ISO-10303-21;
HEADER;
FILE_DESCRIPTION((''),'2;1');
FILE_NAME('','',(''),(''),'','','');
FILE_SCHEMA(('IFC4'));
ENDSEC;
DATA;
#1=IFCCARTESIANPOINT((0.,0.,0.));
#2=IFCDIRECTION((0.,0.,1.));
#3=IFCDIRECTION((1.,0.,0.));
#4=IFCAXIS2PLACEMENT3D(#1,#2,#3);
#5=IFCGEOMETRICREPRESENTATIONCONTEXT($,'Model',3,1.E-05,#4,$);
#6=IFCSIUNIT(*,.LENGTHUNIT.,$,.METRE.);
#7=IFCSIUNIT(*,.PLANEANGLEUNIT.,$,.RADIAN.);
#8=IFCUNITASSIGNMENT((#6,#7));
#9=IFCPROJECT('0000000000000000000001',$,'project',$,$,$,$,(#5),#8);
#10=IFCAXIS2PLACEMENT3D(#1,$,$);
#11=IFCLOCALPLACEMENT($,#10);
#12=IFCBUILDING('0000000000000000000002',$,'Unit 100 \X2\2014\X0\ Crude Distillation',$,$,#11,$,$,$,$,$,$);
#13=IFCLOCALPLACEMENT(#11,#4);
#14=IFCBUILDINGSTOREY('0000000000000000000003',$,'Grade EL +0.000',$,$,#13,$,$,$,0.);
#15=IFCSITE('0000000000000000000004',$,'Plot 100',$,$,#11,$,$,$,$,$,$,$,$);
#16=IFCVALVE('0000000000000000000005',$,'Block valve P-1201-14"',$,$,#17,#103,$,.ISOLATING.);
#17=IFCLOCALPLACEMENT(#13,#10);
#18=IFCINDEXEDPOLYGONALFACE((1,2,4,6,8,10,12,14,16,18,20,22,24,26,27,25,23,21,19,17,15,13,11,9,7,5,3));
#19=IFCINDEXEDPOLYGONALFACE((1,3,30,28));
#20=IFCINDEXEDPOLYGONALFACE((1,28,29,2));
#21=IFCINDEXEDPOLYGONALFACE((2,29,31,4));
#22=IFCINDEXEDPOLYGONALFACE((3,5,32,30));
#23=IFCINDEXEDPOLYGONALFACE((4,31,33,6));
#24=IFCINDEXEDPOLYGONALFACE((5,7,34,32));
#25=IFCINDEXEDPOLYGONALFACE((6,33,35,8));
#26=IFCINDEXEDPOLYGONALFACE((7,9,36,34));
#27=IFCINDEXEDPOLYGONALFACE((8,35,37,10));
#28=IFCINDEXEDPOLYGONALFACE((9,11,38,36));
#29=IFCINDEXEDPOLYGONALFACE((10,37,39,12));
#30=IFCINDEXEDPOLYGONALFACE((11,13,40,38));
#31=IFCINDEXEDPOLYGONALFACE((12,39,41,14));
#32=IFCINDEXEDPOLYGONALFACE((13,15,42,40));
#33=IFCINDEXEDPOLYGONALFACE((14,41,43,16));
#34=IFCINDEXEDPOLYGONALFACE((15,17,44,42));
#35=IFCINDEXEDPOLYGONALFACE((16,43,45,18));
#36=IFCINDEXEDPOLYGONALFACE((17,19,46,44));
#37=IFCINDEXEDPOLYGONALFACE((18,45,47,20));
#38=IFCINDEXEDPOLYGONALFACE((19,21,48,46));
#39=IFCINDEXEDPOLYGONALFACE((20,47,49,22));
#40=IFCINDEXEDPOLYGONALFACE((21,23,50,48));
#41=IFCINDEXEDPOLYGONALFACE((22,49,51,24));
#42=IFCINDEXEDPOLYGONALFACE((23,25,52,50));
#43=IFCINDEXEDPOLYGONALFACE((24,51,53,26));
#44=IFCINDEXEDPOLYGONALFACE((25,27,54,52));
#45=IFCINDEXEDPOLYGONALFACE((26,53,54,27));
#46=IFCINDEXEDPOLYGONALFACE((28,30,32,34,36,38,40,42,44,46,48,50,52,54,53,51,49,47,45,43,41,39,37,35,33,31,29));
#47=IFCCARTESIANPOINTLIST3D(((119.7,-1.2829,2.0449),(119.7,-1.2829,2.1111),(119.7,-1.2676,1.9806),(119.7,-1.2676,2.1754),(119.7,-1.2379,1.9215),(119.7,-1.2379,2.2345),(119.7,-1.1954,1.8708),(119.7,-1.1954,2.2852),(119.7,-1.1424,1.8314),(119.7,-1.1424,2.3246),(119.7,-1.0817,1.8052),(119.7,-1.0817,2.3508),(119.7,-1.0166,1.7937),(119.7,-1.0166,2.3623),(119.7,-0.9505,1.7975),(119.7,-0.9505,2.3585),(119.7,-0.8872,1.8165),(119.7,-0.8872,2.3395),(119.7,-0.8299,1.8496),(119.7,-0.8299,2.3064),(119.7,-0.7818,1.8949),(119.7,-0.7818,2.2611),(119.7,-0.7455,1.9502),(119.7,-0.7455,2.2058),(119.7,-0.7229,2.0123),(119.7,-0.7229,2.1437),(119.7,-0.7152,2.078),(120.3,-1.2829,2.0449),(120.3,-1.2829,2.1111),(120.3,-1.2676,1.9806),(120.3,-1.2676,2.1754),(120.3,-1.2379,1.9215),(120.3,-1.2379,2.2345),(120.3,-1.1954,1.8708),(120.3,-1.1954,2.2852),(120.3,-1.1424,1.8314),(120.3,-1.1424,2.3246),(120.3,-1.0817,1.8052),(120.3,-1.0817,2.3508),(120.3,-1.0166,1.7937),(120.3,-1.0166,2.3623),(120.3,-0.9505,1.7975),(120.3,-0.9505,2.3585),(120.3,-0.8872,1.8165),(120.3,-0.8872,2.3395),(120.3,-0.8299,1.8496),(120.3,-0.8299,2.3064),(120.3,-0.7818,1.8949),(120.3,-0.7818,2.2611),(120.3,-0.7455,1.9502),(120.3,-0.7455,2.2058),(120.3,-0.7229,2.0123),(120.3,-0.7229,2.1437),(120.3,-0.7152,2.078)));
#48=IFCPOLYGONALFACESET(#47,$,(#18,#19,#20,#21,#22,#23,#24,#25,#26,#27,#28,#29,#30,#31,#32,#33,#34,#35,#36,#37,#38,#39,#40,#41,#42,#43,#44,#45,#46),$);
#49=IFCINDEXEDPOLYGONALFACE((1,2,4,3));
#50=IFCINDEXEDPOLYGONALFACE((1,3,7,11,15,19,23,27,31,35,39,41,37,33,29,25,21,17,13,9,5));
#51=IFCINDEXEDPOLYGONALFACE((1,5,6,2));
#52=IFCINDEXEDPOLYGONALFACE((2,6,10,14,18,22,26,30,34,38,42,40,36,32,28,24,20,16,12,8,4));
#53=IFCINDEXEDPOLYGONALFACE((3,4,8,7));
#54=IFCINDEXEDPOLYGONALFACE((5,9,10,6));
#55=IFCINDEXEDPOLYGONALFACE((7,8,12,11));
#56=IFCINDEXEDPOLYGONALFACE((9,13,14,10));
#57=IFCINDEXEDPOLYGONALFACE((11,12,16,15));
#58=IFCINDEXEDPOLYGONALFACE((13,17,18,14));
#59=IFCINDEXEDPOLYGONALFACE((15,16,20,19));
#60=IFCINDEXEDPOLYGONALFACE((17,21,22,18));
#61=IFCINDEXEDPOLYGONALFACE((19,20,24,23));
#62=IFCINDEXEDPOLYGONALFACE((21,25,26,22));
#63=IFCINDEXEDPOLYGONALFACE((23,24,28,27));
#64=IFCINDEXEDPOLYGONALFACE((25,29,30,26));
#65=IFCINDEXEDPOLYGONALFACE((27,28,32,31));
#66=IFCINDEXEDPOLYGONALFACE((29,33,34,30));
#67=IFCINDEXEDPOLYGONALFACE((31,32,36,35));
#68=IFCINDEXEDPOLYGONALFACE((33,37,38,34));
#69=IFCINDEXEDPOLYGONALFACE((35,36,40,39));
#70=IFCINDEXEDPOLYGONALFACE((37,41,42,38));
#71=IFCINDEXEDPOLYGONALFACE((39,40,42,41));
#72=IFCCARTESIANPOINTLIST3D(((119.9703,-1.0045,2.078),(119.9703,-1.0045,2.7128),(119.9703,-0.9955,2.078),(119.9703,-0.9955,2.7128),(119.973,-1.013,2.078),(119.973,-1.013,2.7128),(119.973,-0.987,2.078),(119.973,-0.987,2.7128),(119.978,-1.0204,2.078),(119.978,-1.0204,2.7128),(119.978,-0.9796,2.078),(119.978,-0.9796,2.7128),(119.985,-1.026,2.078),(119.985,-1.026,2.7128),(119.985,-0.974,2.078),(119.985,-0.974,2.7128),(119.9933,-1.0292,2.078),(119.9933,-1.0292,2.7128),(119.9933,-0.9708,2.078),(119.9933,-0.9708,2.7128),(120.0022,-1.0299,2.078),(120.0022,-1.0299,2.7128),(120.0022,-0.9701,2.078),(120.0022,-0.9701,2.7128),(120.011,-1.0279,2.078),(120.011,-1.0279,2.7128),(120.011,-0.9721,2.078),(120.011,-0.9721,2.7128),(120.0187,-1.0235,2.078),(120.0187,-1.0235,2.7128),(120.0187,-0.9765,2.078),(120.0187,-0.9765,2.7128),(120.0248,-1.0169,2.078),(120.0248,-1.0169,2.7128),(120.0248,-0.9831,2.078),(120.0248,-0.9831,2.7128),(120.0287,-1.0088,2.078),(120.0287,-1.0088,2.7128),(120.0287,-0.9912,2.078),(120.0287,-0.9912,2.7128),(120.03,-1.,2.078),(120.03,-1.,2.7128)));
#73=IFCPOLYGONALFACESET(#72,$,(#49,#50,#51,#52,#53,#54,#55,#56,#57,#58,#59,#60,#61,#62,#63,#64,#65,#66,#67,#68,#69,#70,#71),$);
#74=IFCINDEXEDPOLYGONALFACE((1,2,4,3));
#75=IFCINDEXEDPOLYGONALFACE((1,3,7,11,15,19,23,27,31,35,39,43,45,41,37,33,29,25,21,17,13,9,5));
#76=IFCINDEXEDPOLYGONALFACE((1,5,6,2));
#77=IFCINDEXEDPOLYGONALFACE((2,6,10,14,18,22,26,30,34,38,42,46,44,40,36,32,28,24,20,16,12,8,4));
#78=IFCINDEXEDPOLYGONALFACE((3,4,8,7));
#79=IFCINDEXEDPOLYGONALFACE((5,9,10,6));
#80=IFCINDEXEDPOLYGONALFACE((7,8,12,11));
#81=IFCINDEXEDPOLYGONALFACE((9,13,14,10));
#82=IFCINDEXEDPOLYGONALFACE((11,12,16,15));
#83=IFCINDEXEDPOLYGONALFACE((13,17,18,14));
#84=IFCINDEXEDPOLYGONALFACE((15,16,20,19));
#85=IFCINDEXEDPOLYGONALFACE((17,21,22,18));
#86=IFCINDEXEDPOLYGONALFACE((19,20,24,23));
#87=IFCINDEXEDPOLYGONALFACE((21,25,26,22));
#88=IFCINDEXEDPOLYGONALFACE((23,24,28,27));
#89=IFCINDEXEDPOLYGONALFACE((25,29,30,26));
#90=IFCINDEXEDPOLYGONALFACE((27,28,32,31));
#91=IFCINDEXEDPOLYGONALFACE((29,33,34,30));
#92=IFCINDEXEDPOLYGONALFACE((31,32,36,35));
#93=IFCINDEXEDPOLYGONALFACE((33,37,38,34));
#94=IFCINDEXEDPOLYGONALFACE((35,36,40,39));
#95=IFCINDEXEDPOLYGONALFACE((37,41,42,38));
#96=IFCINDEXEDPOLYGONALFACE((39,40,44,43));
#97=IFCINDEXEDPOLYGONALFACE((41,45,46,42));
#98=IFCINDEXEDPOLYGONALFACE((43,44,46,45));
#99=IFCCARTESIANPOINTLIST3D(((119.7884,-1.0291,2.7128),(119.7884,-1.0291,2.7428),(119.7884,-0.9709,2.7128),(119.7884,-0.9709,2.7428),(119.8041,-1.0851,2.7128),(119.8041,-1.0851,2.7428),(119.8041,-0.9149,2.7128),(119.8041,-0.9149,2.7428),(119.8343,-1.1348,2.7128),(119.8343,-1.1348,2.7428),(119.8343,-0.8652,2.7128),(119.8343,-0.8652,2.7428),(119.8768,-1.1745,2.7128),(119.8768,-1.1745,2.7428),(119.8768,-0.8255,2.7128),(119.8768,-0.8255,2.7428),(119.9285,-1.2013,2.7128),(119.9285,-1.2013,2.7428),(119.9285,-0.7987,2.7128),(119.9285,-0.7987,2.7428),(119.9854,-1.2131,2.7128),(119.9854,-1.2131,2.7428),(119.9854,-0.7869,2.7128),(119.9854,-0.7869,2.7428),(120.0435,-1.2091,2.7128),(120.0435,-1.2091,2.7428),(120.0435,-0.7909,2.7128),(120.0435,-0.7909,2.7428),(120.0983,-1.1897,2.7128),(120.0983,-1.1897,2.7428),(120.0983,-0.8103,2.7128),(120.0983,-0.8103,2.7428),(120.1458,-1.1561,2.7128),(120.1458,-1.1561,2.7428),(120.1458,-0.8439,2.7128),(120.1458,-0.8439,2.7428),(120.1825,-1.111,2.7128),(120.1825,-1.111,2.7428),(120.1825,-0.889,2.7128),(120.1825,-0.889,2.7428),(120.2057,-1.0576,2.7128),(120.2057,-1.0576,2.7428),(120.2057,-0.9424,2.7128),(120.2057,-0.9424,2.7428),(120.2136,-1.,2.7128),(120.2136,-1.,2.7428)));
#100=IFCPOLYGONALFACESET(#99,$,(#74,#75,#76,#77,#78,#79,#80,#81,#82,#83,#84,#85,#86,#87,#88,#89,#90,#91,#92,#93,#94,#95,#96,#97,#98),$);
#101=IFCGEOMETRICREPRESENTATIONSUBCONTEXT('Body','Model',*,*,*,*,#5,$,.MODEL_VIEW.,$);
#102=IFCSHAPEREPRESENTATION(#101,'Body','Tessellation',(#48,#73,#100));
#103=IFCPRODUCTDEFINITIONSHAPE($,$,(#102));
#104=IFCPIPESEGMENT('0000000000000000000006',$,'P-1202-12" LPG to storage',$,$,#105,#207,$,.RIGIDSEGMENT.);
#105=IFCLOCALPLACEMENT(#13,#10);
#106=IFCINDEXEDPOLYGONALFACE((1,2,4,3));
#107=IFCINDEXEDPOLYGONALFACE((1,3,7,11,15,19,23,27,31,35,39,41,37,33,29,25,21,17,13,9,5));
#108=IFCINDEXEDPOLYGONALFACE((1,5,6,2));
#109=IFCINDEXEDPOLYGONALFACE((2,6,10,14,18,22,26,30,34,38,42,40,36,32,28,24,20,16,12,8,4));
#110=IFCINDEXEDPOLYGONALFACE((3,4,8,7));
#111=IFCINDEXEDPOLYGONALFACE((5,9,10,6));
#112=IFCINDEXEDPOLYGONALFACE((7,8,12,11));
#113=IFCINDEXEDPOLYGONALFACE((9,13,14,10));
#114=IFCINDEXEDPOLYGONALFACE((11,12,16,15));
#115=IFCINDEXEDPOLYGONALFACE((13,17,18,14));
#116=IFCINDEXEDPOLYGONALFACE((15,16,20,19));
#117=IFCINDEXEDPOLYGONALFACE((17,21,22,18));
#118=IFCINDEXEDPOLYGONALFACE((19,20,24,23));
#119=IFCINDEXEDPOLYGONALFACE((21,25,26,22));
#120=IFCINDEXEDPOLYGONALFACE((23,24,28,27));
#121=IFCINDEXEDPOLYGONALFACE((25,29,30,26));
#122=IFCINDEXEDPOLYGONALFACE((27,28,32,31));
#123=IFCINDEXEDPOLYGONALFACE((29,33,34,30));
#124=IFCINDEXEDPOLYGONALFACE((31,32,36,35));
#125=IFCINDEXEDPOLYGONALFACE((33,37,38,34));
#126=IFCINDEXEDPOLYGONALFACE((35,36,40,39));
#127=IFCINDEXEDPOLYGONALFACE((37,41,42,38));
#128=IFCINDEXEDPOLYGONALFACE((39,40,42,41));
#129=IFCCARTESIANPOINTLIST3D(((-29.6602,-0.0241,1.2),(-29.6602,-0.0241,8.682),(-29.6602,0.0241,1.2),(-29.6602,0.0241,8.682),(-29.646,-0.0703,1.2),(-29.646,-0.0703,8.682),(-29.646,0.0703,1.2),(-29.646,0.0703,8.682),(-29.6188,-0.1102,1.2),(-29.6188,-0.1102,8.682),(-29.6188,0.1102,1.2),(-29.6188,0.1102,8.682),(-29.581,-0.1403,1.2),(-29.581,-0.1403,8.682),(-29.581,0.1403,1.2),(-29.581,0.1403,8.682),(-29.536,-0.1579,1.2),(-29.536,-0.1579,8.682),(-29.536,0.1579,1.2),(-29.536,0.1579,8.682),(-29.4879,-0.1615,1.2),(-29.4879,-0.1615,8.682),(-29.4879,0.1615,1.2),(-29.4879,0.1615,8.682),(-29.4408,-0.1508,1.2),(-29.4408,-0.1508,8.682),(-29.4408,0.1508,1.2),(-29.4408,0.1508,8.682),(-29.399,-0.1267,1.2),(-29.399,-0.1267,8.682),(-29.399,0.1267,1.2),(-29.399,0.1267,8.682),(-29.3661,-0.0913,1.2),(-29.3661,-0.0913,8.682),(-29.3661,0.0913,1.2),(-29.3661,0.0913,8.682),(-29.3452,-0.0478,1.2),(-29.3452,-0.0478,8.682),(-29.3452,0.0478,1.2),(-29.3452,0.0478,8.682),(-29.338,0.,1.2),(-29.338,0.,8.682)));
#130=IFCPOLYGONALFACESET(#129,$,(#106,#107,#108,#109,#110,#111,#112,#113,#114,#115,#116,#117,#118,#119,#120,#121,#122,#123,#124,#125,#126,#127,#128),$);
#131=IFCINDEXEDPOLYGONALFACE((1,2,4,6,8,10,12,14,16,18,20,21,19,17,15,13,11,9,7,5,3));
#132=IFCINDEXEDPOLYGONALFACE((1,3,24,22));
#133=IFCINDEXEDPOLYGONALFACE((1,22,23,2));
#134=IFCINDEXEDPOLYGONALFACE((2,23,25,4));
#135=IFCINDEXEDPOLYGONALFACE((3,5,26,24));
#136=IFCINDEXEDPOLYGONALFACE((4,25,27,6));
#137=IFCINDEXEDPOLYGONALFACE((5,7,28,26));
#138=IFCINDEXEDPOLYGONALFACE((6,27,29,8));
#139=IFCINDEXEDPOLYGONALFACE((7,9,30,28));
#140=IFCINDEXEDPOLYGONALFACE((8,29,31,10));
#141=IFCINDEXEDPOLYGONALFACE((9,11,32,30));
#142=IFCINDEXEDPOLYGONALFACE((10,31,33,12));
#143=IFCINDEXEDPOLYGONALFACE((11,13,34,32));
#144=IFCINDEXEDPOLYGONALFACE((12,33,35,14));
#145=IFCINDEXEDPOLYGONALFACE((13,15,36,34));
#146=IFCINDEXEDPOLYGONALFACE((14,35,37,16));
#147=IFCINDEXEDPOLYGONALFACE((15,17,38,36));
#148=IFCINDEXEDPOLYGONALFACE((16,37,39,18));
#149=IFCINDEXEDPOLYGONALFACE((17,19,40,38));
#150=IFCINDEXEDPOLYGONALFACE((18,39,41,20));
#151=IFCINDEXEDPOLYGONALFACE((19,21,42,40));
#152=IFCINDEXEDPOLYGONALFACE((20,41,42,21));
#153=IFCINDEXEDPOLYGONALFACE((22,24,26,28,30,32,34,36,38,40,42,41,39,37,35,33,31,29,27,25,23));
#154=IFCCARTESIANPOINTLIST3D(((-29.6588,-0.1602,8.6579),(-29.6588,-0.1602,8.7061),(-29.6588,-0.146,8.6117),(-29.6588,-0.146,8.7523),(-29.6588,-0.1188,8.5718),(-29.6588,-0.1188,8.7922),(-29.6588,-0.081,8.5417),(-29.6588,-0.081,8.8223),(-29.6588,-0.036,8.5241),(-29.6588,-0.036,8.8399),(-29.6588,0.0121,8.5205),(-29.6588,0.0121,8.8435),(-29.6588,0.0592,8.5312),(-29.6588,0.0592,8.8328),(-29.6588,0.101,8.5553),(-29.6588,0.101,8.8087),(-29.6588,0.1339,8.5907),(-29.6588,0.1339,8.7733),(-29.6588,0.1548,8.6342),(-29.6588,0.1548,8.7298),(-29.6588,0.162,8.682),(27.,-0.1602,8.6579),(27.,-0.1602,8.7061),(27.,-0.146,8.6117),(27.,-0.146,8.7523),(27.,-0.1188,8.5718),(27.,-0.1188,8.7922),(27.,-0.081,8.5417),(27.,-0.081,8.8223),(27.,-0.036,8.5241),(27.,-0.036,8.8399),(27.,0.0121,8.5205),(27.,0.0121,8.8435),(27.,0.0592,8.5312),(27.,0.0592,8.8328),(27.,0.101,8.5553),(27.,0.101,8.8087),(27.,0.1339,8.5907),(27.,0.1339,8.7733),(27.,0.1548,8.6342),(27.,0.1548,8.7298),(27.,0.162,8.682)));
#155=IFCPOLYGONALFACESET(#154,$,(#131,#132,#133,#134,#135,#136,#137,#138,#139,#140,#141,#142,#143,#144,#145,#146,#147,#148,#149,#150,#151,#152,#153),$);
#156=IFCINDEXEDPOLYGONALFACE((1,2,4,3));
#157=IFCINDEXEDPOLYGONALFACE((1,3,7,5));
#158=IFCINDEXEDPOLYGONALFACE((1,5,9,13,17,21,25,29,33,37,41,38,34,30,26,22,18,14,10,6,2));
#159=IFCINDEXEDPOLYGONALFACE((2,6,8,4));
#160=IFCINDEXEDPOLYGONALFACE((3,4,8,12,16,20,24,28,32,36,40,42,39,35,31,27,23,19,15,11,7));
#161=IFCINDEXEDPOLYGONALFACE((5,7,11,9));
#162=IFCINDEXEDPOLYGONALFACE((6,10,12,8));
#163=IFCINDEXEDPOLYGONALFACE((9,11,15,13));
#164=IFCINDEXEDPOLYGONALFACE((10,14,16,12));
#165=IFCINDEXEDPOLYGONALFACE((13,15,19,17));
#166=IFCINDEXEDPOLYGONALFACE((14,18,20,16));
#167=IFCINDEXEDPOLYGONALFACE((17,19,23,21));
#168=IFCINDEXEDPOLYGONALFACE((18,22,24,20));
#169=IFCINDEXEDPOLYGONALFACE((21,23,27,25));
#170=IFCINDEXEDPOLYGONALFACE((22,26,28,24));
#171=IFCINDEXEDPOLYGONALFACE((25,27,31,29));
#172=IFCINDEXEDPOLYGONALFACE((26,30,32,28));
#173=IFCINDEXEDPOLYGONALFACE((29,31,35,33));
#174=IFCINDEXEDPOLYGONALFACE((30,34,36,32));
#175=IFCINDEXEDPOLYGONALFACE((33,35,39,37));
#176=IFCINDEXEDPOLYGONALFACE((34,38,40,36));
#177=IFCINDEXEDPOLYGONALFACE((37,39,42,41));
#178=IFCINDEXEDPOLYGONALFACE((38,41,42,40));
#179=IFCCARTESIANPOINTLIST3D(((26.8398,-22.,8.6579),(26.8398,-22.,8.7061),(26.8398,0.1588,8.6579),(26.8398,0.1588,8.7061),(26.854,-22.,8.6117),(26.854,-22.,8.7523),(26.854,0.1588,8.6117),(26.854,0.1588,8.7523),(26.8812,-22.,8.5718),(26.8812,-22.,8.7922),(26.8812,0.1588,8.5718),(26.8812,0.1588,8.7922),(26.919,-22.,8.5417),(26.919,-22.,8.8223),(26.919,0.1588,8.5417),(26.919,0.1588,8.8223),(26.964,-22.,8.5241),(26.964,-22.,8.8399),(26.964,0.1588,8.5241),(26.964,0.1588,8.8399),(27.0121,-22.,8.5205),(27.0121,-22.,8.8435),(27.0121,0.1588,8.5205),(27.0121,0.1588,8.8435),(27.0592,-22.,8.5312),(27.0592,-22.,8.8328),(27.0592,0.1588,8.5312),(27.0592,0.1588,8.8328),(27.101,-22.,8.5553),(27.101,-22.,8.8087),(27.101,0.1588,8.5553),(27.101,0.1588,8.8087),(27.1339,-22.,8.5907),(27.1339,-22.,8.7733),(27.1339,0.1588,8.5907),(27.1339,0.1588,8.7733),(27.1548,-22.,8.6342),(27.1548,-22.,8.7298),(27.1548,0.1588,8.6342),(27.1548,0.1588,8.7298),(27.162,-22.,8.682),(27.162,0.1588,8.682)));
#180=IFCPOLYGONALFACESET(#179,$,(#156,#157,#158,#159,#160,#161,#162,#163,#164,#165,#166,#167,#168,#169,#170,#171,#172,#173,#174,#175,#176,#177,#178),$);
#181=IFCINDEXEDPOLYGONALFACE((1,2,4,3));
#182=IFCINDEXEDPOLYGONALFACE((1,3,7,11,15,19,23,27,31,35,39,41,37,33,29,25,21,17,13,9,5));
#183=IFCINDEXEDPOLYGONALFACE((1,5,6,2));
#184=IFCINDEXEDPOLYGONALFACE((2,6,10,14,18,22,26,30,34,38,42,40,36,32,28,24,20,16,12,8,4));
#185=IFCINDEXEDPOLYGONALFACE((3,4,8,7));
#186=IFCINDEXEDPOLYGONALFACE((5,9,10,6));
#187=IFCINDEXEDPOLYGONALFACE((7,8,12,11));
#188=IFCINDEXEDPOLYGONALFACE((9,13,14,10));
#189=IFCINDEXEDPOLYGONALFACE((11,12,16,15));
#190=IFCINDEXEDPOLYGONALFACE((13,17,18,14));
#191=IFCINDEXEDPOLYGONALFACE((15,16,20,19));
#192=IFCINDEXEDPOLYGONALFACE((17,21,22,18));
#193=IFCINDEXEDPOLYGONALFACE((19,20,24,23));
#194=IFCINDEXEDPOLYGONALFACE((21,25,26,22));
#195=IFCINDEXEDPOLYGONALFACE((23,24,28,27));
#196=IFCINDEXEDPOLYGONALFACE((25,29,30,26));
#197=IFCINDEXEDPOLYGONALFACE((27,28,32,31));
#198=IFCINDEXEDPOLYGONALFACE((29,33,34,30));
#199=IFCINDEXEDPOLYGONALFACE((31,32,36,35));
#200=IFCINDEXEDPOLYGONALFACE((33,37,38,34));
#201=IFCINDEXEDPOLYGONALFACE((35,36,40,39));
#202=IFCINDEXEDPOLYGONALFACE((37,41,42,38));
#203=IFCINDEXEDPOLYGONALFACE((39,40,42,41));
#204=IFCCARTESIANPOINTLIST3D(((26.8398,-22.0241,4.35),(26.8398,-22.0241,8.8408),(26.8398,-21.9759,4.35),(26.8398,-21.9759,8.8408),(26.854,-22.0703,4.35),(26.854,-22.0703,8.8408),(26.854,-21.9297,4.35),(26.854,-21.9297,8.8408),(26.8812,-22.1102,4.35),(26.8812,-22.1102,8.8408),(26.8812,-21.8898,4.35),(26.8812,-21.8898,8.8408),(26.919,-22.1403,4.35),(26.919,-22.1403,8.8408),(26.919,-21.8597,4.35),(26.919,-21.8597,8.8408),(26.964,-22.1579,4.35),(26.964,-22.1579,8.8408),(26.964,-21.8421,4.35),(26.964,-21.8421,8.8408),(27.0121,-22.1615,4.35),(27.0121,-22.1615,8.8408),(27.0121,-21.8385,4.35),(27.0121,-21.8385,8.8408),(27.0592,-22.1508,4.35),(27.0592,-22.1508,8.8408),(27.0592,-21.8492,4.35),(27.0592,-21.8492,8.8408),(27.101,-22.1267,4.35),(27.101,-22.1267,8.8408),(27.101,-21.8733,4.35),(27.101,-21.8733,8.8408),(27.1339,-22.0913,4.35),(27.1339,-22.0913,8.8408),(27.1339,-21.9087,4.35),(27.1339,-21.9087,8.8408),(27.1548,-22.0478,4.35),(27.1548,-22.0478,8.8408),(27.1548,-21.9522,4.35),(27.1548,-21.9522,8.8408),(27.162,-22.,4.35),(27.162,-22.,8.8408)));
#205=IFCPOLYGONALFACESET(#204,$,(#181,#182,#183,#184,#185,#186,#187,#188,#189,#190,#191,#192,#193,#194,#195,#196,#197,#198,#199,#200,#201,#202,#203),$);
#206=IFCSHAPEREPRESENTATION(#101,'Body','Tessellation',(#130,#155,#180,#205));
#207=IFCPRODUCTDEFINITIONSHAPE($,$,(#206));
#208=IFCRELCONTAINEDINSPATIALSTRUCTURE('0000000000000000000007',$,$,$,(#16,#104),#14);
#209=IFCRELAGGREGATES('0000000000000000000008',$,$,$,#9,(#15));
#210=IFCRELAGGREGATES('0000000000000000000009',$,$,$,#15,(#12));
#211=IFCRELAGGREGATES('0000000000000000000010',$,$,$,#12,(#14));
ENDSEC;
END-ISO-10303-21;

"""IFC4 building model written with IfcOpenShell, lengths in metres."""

from ifc_helpers import new_model, si_unit, frame, origin, origin_with_axes, origin_2d, place, context, subcontext, project, spatial, circle, extrude, element, save


model = new_model("IFC4")

# Units and contexts
model_context = context("Model", 3, precision=1e-05, world=origin_with_axes())
body_context = subcontext(model_context, "Body", "Model", "MODEL_VIEW")
ifc_project = project(units=[si_unit("LENGTHUNIT", "METRE"), si_unit("PLANEANGLEUNIT", "RADIAN")], contexts=[model_context])

# Site, building, storey
placement = place(None, origin())
site = spatial("IfcSite", under=ifc_project, at=placement, Name="Plot 100")
building = spatial("IfcBuilding", under=site, at=placement, Name="Unit 100 — Crude Distillation")
storey_placement = place(placement, origin_with_axes())
storey = spatial("IfcBuildingStorey", under=building, at=storey_placement, Name="Grade EL +0.000", Elevation=0.0)

# Valve
valve_1_placement = place(storey_placement, origin_with_axes())
element("IfcValve", 1, at=valve_1_placement, inside=storey, Name="Block valve P-1201-14\"", PredefinedType="ISOLATING", context=body_context, shape_type="SweptSolid", body=[
    extrude(circle(Radius=0.2848, at=origin_2d()), frame((119.7, -1.0, 2.078), z_axis=(1.0, 0.0, 0.0), x_axis=(0.0, 1.0, 0.0)), (0.0, 0.0, 1.0), 0.6),
    extrude(circle(Radius=0.03, at=origin_2d()), frame((120.0, -1.0, 2.078), z_axis=(0.0, 0.0, 1.0), x_axis=(1.0, 0.0, 0.0)), (0.0, 0.0, 1.0), 0.6348),
    extrude(circle(Radius=0.2136, at=origin_2d()), frame((120.0, -1.0, 2.7128), z_axis=(0.0, 0.0, 1.0), x_axis=(1.0, 0.0, 0.0)), (0.0, 0.0, 1.0), 0.03),
])

# Pipe segment
pipe_segment_1_placement = place(storey_placement, origin_with_axes())
element("IfcPipeSegment", 2, at=pipe_segment_1_placement, inside=storey, Name="P-1202-12\" LPG to storage", PredefinedType="RIGIDSEGMENT", context=body_context, shape_type="SweptSolid", body=[
    extrude(circle(Radius=0.162, at=origin_2d()), frame((-29.5, 0.0, 1.2), z_axis=(0.0, 0.0, 1.0), x_axis=(1.0, 0.0, 0.0)), (0.0, 0.0, 1.0), 7.482),
    extrude(circle(Radius=0.162, at=origin_2d()), frame((-29.6588, 0.0, 8.682), z_axis=(1.0, 0.0, 0.0), x_axis=(0.0, 1.0, 0.0)), (0.0, 0.0, 1.0), 56.6588),
    extrude(circle(Radius=0.162, at=origin_2d()), frame((27.0, 0.1588, 8.682), z_axis=(0.0, -1.0, 0.0), x_axis=(1.0, 0.0, 0.0)), (0.0, 0.0, 1.0), 22.1588),
    extrude(circle(Radius=0.162, at=origin_2d()), frame((27.0, -22.0, 8.8408), z_axis=(0.0, 0.0, -1.0), x_axis=(1.0, 0.0, 0.0)), (0.0, 0.0, 1.0), 4.4908),
])

save(model, "model.ifc")
